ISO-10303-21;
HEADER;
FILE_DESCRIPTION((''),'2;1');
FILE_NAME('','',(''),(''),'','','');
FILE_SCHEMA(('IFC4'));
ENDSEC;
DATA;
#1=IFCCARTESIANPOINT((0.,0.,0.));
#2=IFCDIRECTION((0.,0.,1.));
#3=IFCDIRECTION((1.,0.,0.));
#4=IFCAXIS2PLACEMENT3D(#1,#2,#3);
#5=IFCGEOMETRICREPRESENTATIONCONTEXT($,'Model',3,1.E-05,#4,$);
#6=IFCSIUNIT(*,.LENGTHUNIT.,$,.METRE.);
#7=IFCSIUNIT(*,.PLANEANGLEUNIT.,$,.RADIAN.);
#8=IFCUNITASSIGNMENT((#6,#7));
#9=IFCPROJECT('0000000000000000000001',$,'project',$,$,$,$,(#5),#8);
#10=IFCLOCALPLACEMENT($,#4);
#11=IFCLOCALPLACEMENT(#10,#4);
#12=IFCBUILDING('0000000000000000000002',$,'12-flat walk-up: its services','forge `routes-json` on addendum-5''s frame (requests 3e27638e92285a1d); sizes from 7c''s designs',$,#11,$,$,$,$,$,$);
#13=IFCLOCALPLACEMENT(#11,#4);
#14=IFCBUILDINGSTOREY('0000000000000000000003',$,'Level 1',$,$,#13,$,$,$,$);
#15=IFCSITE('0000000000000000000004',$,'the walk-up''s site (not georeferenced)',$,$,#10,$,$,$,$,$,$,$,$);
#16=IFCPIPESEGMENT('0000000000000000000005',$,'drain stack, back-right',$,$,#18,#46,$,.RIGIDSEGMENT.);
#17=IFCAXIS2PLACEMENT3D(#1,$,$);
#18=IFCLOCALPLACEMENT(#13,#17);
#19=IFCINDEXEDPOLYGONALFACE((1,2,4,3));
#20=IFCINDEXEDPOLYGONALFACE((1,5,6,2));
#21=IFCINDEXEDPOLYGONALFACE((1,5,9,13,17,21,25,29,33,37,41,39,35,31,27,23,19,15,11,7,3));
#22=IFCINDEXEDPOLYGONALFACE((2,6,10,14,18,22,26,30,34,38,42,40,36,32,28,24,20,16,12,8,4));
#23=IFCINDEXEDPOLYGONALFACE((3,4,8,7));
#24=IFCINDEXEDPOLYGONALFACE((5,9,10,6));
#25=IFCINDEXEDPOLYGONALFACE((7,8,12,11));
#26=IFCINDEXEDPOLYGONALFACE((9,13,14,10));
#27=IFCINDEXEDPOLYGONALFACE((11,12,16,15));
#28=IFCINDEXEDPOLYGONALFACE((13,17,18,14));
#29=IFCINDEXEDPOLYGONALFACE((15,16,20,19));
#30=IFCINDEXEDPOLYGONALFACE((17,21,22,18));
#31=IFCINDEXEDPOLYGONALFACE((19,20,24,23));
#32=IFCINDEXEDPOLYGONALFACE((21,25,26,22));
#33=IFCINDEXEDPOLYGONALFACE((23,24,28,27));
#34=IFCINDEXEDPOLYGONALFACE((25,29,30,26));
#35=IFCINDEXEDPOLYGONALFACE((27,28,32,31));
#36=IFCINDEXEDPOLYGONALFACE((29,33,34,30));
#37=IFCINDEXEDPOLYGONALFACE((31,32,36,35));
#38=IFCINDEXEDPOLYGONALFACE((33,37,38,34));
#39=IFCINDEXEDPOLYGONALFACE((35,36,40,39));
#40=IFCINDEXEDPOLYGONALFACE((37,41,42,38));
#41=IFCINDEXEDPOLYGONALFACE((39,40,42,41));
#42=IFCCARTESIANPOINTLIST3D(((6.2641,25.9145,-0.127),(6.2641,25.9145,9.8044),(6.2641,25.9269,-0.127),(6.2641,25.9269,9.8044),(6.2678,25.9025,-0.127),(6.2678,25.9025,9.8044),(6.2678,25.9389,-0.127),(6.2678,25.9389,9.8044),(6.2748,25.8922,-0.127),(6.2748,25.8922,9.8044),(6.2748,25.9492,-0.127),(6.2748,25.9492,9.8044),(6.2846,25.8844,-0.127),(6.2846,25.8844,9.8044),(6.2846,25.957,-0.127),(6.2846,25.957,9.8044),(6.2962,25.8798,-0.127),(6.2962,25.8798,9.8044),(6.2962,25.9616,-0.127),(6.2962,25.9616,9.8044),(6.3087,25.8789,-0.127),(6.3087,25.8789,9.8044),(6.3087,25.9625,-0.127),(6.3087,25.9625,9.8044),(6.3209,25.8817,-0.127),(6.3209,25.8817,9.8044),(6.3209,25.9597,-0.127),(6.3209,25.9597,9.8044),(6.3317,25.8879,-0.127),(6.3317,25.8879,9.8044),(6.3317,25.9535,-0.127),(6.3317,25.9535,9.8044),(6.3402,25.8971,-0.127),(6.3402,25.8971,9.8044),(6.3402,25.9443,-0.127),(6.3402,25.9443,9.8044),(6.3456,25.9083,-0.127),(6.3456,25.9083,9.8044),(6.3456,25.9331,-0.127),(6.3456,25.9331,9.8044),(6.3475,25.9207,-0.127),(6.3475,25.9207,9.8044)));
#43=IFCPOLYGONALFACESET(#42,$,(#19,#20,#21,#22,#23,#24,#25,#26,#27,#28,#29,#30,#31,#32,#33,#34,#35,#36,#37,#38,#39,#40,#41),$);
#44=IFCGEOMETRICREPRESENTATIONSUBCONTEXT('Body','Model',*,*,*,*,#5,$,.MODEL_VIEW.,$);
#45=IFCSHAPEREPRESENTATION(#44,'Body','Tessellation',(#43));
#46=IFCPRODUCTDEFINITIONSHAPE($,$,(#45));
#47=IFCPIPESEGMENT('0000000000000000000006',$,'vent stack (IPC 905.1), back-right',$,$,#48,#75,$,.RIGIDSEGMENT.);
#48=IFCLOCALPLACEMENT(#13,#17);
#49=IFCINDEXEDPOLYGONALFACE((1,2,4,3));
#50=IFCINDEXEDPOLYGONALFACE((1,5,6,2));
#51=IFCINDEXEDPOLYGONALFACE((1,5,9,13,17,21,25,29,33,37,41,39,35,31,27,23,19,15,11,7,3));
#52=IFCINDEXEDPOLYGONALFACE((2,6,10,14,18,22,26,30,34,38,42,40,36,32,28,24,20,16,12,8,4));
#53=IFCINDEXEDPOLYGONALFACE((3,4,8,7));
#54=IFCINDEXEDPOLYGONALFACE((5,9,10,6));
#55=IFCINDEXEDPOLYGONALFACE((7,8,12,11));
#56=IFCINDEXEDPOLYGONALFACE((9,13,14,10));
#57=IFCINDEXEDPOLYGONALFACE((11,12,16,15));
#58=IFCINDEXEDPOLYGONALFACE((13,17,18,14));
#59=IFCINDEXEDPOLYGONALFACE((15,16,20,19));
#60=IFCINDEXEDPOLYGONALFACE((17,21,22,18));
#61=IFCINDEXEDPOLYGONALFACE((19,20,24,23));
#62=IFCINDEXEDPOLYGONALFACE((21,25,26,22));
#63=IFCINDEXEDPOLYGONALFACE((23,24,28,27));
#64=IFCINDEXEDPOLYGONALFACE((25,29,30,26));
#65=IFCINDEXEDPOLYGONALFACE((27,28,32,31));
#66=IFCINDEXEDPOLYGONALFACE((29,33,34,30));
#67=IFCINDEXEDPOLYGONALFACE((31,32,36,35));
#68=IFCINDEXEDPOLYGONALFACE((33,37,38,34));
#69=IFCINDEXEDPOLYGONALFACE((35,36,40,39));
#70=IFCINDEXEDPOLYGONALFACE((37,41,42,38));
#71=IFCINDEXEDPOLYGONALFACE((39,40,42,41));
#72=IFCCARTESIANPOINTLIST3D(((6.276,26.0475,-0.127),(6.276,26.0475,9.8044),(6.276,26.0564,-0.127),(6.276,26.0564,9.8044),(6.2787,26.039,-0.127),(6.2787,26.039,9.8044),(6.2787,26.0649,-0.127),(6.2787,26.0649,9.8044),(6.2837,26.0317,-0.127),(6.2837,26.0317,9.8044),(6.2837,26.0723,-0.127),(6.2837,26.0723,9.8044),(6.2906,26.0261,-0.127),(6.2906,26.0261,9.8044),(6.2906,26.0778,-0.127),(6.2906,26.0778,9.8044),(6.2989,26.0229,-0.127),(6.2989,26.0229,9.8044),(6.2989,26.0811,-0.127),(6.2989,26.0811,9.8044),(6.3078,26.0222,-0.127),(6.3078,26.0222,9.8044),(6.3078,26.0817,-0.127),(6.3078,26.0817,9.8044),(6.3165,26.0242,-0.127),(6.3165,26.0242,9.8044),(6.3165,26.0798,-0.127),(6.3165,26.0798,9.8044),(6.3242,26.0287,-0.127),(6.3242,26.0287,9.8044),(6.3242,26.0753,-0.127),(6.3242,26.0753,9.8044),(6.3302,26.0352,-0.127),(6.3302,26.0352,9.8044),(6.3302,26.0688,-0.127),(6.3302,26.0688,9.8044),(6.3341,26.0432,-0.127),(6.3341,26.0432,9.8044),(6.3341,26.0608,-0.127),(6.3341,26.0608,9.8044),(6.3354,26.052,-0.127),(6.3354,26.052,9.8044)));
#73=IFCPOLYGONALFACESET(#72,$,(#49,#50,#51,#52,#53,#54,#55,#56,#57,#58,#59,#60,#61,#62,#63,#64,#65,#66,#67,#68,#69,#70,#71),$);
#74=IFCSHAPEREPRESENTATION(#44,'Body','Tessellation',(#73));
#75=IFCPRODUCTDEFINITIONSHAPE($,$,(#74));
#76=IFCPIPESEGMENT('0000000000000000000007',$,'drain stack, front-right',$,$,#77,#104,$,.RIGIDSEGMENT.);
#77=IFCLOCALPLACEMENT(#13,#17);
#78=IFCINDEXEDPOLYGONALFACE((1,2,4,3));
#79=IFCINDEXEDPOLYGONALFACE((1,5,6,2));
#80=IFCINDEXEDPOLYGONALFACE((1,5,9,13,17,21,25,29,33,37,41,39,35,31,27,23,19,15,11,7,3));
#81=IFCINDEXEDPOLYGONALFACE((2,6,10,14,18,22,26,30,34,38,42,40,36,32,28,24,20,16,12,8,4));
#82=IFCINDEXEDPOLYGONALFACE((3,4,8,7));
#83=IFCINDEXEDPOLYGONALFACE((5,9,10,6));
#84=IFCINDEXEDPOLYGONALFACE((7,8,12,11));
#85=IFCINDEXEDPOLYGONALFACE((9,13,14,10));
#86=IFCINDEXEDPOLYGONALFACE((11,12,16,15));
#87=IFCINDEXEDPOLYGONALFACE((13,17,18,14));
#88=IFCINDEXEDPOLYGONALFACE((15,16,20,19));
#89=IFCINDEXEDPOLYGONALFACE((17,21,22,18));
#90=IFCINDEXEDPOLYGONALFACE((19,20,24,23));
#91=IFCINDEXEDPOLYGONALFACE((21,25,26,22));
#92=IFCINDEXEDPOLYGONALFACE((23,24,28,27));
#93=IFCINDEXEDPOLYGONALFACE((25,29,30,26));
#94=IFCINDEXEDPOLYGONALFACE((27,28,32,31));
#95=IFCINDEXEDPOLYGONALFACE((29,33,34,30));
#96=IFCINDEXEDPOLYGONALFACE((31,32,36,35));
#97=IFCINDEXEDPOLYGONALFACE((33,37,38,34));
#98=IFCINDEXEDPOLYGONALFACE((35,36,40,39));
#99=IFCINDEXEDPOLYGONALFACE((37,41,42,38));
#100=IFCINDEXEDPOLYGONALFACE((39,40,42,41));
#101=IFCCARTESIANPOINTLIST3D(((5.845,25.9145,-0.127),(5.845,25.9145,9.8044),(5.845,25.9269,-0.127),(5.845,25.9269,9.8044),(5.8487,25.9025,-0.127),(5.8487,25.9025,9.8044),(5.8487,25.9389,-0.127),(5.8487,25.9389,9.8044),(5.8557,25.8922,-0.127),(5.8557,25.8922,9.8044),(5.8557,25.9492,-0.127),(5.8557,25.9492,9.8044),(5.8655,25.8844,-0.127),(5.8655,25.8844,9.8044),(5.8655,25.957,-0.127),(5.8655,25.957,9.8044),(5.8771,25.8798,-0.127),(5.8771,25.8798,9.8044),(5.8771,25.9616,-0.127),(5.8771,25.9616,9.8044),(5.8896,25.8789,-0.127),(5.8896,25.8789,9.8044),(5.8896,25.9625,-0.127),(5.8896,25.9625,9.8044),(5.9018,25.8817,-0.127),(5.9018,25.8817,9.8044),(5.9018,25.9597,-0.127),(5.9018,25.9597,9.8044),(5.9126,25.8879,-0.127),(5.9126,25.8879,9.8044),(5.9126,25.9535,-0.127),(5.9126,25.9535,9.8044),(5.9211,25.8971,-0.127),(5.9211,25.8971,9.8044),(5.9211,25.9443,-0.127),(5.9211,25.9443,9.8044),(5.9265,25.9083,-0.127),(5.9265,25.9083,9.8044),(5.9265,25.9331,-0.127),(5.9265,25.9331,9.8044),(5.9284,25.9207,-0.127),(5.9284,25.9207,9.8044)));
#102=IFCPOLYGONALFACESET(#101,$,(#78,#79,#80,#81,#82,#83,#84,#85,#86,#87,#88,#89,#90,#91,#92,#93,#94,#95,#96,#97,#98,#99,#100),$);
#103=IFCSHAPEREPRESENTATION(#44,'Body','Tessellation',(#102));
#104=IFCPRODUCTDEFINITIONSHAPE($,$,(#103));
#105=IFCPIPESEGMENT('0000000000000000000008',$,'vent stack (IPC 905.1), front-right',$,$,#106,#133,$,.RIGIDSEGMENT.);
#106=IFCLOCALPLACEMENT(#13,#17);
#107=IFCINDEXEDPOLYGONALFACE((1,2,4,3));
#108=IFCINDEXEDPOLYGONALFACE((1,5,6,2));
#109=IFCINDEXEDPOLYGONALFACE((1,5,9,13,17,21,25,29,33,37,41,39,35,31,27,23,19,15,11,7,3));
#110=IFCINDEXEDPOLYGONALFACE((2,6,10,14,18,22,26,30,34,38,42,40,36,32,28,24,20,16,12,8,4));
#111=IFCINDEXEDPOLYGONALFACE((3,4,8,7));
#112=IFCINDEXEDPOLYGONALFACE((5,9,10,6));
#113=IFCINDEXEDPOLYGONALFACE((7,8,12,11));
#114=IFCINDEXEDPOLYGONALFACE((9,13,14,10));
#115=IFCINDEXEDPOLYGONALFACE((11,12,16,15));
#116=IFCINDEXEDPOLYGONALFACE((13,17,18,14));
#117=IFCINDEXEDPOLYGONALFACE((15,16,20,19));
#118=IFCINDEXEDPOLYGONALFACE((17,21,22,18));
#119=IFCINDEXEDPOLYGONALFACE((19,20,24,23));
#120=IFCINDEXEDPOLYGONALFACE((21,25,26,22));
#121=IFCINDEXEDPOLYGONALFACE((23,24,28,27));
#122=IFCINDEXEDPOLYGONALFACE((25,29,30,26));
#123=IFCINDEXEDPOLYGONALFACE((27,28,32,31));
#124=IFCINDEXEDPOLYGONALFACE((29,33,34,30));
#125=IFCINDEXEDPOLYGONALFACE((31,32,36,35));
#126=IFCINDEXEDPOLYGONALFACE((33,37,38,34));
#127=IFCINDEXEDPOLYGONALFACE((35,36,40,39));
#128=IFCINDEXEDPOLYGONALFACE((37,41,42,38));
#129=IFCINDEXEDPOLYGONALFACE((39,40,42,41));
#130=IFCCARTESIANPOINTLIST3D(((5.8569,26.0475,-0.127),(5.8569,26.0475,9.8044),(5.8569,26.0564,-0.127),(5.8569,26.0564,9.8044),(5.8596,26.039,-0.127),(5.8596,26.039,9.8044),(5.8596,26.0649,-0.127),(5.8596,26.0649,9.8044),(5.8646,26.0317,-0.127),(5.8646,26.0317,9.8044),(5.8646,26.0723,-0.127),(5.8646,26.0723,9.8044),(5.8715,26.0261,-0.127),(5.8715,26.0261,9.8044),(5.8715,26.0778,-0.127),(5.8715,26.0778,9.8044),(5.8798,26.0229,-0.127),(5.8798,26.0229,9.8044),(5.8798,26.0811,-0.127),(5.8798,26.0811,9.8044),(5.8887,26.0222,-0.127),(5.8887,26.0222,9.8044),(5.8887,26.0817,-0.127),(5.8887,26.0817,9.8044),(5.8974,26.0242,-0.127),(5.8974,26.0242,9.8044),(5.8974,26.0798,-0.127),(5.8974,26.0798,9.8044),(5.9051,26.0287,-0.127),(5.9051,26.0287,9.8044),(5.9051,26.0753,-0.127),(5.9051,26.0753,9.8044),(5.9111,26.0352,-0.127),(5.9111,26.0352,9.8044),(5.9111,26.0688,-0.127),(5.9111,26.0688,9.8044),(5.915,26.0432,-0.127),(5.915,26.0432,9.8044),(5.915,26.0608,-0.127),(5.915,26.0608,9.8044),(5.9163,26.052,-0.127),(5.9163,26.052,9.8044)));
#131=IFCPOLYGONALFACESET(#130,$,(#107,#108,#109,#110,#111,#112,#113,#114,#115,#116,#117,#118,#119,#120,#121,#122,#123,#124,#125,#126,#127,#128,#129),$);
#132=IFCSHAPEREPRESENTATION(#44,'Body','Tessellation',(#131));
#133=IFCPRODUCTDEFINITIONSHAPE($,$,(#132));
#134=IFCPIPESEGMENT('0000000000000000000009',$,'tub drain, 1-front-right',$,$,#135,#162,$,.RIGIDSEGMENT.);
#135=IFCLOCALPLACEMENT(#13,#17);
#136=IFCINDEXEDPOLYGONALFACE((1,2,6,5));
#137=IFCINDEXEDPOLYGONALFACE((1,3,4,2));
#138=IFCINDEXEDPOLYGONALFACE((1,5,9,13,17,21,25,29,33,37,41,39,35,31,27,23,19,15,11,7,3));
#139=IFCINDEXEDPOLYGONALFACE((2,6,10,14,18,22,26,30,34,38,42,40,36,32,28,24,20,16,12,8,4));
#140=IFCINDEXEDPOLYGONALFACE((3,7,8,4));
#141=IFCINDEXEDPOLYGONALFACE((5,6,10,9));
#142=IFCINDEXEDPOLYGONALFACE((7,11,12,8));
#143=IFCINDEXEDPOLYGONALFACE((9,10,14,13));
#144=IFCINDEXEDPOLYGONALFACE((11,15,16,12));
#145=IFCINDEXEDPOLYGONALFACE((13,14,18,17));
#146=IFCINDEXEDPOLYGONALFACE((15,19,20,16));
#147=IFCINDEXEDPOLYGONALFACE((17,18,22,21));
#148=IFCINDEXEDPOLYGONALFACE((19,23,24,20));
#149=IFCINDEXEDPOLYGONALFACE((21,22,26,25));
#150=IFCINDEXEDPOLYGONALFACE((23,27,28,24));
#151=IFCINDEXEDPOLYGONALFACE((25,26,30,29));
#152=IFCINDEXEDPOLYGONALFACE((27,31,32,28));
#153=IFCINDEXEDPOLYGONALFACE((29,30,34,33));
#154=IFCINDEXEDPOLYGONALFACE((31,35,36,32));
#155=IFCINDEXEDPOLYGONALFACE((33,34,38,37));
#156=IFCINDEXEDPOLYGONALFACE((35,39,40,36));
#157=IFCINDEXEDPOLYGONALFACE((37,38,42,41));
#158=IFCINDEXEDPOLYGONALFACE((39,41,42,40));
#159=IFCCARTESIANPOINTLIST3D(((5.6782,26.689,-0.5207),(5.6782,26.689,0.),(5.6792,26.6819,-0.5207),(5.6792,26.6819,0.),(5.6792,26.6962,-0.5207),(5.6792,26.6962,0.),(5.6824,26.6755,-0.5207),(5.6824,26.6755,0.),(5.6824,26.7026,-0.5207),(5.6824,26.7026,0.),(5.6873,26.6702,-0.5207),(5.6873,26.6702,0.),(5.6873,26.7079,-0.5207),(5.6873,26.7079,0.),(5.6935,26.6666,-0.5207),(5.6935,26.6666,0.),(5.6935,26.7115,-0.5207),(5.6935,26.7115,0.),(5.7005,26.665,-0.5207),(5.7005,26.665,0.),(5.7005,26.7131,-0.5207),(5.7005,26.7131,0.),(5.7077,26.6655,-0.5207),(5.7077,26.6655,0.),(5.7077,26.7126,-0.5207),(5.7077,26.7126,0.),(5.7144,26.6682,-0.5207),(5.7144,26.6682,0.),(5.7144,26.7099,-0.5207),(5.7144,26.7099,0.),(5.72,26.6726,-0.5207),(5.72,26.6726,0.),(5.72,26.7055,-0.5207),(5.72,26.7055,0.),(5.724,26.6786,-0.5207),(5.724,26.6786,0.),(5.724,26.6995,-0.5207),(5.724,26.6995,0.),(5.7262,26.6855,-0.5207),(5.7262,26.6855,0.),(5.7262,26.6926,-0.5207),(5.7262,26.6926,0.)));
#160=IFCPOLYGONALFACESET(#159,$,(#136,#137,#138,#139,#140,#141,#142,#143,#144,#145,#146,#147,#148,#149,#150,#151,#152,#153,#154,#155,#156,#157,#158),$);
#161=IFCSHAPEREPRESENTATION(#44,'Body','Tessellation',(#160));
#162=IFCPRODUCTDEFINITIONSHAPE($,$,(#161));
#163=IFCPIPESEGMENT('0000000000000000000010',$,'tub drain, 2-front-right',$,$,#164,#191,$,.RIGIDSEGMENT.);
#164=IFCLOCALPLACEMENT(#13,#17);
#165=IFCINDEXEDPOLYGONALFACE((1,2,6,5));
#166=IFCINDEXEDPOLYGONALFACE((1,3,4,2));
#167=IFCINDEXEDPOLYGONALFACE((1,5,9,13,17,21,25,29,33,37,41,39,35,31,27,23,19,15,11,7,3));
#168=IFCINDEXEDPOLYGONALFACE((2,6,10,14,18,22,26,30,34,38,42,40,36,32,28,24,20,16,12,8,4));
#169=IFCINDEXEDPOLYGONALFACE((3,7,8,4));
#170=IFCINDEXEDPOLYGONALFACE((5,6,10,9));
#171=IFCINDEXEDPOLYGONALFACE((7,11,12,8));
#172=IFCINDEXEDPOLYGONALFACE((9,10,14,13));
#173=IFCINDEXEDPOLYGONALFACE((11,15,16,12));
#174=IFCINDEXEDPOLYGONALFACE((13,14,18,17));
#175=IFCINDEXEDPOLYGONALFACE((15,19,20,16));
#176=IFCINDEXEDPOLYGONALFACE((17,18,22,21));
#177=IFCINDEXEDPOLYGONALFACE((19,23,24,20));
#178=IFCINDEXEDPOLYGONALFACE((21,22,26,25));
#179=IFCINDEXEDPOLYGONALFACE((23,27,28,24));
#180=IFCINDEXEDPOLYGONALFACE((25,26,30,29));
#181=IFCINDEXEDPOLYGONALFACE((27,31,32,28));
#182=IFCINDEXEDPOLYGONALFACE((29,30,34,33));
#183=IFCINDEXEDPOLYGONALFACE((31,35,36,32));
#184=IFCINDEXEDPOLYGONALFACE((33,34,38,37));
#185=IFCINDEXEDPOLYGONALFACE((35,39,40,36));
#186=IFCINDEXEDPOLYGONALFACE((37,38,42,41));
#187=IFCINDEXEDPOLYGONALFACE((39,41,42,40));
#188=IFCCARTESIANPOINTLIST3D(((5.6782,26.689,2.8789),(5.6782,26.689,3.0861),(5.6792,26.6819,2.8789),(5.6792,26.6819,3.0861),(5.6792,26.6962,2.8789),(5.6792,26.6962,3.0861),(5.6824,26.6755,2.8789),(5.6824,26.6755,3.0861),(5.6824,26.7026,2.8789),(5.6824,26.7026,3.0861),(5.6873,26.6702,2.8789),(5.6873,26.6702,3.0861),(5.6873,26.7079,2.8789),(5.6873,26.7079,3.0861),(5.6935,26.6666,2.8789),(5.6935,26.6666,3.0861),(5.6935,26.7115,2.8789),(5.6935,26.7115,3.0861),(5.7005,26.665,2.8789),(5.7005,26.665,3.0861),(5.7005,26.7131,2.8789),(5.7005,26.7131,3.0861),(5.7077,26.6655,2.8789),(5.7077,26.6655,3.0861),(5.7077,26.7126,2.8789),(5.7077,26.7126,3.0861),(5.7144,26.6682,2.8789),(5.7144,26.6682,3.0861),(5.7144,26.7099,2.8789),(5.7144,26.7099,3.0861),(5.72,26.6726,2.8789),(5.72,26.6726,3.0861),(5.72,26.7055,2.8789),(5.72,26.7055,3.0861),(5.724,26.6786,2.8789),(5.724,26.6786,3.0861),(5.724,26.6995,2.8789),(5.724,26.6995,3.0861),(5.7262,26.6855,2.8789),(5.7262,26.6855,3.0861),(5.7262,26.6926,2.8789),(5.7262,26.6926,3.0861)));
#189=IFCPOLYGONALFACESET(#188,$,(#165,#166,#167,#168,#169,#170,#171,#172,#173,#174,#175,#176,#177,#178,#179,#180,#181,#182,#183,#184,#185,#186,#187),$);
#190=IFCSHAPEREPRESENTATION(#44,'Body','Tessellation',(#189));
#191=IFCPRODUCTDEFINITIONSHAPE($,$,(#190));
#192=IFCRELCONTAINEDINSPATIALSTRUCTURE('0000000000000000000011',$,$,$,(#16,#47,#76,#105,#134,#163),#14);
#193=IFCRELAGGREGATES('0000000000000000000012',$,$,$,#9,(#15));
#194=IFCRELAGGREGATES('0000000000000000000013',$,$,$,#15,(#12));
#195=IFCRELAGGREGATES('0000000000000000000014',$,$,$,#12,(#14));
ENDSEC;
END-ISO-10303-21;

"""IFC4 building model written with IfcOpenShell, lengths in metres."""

from ifc_helpers import new_model, entity, si_unit, frame, origin_with_axes, place, context, subcontext, project, spatial, element, save


model = new_model("IFC4")

# Units and contexts
model_context = context("Model", 3, precision=1e-05, world=origin_with_axes())
body_context = subcontext(model_context, "Body", "Model", "MODEL_VIEW")
ifc_project = project(units=[si_unit("LENGTHUNIT", "METRE"), si_unit("PLANEANGLEUNIT", "RADIAN")], contexts=[model_context])

# Site, building, storey
site_placement = place(None, origin_with_axes())
site = spatial("IfcSite", under=ifc_project, at=site_placement, Name="the walk-up's site (not georeferenced)")
building_placement = place(site_placement, origin_with_axes())
building = spatial("IfcBuilding", under=site, at=building_placement, Name="12-flat walk-up: its services", Description="forge `routes-json` on addendum-5's frame (requests 3e27638e92285a1d); sizes from 7c's designs")
storey_placement = place(building_placement, origin_with_axes())
storey = spatial("IfcBuildingStorey", under=building, at=storey_placement, Name="Level 1")

# Pipe segments
pipe_segment_1_placement = place(storey_placement, frame((6.3056, 25.9207, -0.127), z_axis=(0.0, 0.0, 1.0), x_axis=(1.0, 0.0, 0.0)))
element("IfcPipeSegment", 1, at=pipe_segment_1_placement, inside=storey, Name="drain stack, back-right", PredefinedType="RIGIDSEGMENT", context=body_context, shape_type="AdvancedSweptSolid", body=[
    entity("IfcSweptDiskSolid", entity("IfcPolyline", [entity("IfcCartesianPoint", [0.0, 0.0, 0.0]), entity("IfcCartesianPoint", [0.0, 0.0, 9.9314])]), 0.0419),
])
pipe_segment_2_placement = place(storey_placement, frame((6.3056, 26.052, -0.127), z_axis=(0.0, 0.0, 1.0), x_axis=(1.0, 0.0, 0.0)))
element("IfcPipeSegment", 2, at=pipe_segment_2_placement, inside=storey, Name="vent stack (IPC 905.1), back-right", PredefinedType="RIGIDSEGMENT", context=body_context, shape_type="AdvancedSweptSolid", body=[
    entity("IfcSweptDiskSolid", entity("IfcPolyline", [entity("IfcCartesianPoint", [0.0, 0.0, 0.0]), entity("IfcCartesianPoint", [0.0, 0.0, 9.9314])]), 0.0298),
])
pipe_segment_3_placement = place(storey_placement, frame((5.8864, 25.9207, -0.127), z_axis=(0.0, 0.0, 1.0), x_axis=(1.0, 0.0, 0.0)))
element("IfcPipeSegment", 3, at=pipe_segment_3_placement, inside=storey, Name="drain stack, front-right", PredefinedType="RIGIDSEGMENT", context=body_context, shape_type="AdvancedSweptSolid", body=[
    entity("IfcSweptDiskSolid", entity("IfcPolyline", [entity("IfcCartesianPoint", [0.0, 0.0, 0.0]), entity("IfcCartesianPoint", [0.0, 0.0, 9.9314])]), 0.0419),
])
pipe_segment_4_placement = place(storey_placement, frame((5.8864, 26.052, -0.127), z_axis=(0.0, 0.0, 1.0), x_axis=(1.0, 0.0, 0.0)))
element("IfcPipeSegment", 4, at=pipe_segment_4_placement, inside=storey, Name="vent stack (IPC 905.1), front-right", PredefinedType="RIGIDSEGMENT", context=body_context, shape_type="AdvancedSweptSolid", body=[
    entity("IfcSweptDiskSolid", entity("IfcPolyline", [entity("IfcCartesianPoint", [0.0, 0.0, 0.0]), entity("IfcCartesianPoint", [0.0, 0.0, 9.9314])]), 0.0298),
])
pipe_segment_5_placement = place(storey_placement, frame((5.7023, 26.6891, 0.0), z_axis=(0.0, 0.0, 1.0), x_axis=(1.0, 0.0, 0.0)))
element("IfcPipeSegment", 5, at=pipe_segment_5_placement, inside=storey, Name="tub drain, 1-front-right", PredefinedType="RIGIDSEGMENT", context=body_context, shape_type="AdvancedSweptSolid", body=[
    entity("IfcSweptDiskSolid", entity("IfcPolyline", [entity("IfcCartesianPoint", [0.0, 0.0, 0.0]), entity("IfcCartesianPoint", [0.0, 0.0, -0.5207])]), 0.0241),
])
pipe_segment_6_placement = place(storey_placement, frame((5.7023, 26.6891, 3.0861), z_axis=(0.0, 0.0, 1.0), x_axis=(1.0, 0.0, 0.0)))
element("IfcPipeSegment", 6, at=pipe_segment_6_placement, inside=storey, Name="tub drain, 2-front-right", PredefinedType="RIGIDSEGMENT", context=body_context, shape_type="AdvancedSweptSolid", body=[
    entity("IfcSweptDiskSolid", entity("IfcPolyline", [entity("IfcCartesianPoint", [0.0, 0.0, 0.0]), entity("IfcCartesianPoint", [0.0, 0.0, -0.2072])]), 0.0241),
])

save(model, "model.ifc")
